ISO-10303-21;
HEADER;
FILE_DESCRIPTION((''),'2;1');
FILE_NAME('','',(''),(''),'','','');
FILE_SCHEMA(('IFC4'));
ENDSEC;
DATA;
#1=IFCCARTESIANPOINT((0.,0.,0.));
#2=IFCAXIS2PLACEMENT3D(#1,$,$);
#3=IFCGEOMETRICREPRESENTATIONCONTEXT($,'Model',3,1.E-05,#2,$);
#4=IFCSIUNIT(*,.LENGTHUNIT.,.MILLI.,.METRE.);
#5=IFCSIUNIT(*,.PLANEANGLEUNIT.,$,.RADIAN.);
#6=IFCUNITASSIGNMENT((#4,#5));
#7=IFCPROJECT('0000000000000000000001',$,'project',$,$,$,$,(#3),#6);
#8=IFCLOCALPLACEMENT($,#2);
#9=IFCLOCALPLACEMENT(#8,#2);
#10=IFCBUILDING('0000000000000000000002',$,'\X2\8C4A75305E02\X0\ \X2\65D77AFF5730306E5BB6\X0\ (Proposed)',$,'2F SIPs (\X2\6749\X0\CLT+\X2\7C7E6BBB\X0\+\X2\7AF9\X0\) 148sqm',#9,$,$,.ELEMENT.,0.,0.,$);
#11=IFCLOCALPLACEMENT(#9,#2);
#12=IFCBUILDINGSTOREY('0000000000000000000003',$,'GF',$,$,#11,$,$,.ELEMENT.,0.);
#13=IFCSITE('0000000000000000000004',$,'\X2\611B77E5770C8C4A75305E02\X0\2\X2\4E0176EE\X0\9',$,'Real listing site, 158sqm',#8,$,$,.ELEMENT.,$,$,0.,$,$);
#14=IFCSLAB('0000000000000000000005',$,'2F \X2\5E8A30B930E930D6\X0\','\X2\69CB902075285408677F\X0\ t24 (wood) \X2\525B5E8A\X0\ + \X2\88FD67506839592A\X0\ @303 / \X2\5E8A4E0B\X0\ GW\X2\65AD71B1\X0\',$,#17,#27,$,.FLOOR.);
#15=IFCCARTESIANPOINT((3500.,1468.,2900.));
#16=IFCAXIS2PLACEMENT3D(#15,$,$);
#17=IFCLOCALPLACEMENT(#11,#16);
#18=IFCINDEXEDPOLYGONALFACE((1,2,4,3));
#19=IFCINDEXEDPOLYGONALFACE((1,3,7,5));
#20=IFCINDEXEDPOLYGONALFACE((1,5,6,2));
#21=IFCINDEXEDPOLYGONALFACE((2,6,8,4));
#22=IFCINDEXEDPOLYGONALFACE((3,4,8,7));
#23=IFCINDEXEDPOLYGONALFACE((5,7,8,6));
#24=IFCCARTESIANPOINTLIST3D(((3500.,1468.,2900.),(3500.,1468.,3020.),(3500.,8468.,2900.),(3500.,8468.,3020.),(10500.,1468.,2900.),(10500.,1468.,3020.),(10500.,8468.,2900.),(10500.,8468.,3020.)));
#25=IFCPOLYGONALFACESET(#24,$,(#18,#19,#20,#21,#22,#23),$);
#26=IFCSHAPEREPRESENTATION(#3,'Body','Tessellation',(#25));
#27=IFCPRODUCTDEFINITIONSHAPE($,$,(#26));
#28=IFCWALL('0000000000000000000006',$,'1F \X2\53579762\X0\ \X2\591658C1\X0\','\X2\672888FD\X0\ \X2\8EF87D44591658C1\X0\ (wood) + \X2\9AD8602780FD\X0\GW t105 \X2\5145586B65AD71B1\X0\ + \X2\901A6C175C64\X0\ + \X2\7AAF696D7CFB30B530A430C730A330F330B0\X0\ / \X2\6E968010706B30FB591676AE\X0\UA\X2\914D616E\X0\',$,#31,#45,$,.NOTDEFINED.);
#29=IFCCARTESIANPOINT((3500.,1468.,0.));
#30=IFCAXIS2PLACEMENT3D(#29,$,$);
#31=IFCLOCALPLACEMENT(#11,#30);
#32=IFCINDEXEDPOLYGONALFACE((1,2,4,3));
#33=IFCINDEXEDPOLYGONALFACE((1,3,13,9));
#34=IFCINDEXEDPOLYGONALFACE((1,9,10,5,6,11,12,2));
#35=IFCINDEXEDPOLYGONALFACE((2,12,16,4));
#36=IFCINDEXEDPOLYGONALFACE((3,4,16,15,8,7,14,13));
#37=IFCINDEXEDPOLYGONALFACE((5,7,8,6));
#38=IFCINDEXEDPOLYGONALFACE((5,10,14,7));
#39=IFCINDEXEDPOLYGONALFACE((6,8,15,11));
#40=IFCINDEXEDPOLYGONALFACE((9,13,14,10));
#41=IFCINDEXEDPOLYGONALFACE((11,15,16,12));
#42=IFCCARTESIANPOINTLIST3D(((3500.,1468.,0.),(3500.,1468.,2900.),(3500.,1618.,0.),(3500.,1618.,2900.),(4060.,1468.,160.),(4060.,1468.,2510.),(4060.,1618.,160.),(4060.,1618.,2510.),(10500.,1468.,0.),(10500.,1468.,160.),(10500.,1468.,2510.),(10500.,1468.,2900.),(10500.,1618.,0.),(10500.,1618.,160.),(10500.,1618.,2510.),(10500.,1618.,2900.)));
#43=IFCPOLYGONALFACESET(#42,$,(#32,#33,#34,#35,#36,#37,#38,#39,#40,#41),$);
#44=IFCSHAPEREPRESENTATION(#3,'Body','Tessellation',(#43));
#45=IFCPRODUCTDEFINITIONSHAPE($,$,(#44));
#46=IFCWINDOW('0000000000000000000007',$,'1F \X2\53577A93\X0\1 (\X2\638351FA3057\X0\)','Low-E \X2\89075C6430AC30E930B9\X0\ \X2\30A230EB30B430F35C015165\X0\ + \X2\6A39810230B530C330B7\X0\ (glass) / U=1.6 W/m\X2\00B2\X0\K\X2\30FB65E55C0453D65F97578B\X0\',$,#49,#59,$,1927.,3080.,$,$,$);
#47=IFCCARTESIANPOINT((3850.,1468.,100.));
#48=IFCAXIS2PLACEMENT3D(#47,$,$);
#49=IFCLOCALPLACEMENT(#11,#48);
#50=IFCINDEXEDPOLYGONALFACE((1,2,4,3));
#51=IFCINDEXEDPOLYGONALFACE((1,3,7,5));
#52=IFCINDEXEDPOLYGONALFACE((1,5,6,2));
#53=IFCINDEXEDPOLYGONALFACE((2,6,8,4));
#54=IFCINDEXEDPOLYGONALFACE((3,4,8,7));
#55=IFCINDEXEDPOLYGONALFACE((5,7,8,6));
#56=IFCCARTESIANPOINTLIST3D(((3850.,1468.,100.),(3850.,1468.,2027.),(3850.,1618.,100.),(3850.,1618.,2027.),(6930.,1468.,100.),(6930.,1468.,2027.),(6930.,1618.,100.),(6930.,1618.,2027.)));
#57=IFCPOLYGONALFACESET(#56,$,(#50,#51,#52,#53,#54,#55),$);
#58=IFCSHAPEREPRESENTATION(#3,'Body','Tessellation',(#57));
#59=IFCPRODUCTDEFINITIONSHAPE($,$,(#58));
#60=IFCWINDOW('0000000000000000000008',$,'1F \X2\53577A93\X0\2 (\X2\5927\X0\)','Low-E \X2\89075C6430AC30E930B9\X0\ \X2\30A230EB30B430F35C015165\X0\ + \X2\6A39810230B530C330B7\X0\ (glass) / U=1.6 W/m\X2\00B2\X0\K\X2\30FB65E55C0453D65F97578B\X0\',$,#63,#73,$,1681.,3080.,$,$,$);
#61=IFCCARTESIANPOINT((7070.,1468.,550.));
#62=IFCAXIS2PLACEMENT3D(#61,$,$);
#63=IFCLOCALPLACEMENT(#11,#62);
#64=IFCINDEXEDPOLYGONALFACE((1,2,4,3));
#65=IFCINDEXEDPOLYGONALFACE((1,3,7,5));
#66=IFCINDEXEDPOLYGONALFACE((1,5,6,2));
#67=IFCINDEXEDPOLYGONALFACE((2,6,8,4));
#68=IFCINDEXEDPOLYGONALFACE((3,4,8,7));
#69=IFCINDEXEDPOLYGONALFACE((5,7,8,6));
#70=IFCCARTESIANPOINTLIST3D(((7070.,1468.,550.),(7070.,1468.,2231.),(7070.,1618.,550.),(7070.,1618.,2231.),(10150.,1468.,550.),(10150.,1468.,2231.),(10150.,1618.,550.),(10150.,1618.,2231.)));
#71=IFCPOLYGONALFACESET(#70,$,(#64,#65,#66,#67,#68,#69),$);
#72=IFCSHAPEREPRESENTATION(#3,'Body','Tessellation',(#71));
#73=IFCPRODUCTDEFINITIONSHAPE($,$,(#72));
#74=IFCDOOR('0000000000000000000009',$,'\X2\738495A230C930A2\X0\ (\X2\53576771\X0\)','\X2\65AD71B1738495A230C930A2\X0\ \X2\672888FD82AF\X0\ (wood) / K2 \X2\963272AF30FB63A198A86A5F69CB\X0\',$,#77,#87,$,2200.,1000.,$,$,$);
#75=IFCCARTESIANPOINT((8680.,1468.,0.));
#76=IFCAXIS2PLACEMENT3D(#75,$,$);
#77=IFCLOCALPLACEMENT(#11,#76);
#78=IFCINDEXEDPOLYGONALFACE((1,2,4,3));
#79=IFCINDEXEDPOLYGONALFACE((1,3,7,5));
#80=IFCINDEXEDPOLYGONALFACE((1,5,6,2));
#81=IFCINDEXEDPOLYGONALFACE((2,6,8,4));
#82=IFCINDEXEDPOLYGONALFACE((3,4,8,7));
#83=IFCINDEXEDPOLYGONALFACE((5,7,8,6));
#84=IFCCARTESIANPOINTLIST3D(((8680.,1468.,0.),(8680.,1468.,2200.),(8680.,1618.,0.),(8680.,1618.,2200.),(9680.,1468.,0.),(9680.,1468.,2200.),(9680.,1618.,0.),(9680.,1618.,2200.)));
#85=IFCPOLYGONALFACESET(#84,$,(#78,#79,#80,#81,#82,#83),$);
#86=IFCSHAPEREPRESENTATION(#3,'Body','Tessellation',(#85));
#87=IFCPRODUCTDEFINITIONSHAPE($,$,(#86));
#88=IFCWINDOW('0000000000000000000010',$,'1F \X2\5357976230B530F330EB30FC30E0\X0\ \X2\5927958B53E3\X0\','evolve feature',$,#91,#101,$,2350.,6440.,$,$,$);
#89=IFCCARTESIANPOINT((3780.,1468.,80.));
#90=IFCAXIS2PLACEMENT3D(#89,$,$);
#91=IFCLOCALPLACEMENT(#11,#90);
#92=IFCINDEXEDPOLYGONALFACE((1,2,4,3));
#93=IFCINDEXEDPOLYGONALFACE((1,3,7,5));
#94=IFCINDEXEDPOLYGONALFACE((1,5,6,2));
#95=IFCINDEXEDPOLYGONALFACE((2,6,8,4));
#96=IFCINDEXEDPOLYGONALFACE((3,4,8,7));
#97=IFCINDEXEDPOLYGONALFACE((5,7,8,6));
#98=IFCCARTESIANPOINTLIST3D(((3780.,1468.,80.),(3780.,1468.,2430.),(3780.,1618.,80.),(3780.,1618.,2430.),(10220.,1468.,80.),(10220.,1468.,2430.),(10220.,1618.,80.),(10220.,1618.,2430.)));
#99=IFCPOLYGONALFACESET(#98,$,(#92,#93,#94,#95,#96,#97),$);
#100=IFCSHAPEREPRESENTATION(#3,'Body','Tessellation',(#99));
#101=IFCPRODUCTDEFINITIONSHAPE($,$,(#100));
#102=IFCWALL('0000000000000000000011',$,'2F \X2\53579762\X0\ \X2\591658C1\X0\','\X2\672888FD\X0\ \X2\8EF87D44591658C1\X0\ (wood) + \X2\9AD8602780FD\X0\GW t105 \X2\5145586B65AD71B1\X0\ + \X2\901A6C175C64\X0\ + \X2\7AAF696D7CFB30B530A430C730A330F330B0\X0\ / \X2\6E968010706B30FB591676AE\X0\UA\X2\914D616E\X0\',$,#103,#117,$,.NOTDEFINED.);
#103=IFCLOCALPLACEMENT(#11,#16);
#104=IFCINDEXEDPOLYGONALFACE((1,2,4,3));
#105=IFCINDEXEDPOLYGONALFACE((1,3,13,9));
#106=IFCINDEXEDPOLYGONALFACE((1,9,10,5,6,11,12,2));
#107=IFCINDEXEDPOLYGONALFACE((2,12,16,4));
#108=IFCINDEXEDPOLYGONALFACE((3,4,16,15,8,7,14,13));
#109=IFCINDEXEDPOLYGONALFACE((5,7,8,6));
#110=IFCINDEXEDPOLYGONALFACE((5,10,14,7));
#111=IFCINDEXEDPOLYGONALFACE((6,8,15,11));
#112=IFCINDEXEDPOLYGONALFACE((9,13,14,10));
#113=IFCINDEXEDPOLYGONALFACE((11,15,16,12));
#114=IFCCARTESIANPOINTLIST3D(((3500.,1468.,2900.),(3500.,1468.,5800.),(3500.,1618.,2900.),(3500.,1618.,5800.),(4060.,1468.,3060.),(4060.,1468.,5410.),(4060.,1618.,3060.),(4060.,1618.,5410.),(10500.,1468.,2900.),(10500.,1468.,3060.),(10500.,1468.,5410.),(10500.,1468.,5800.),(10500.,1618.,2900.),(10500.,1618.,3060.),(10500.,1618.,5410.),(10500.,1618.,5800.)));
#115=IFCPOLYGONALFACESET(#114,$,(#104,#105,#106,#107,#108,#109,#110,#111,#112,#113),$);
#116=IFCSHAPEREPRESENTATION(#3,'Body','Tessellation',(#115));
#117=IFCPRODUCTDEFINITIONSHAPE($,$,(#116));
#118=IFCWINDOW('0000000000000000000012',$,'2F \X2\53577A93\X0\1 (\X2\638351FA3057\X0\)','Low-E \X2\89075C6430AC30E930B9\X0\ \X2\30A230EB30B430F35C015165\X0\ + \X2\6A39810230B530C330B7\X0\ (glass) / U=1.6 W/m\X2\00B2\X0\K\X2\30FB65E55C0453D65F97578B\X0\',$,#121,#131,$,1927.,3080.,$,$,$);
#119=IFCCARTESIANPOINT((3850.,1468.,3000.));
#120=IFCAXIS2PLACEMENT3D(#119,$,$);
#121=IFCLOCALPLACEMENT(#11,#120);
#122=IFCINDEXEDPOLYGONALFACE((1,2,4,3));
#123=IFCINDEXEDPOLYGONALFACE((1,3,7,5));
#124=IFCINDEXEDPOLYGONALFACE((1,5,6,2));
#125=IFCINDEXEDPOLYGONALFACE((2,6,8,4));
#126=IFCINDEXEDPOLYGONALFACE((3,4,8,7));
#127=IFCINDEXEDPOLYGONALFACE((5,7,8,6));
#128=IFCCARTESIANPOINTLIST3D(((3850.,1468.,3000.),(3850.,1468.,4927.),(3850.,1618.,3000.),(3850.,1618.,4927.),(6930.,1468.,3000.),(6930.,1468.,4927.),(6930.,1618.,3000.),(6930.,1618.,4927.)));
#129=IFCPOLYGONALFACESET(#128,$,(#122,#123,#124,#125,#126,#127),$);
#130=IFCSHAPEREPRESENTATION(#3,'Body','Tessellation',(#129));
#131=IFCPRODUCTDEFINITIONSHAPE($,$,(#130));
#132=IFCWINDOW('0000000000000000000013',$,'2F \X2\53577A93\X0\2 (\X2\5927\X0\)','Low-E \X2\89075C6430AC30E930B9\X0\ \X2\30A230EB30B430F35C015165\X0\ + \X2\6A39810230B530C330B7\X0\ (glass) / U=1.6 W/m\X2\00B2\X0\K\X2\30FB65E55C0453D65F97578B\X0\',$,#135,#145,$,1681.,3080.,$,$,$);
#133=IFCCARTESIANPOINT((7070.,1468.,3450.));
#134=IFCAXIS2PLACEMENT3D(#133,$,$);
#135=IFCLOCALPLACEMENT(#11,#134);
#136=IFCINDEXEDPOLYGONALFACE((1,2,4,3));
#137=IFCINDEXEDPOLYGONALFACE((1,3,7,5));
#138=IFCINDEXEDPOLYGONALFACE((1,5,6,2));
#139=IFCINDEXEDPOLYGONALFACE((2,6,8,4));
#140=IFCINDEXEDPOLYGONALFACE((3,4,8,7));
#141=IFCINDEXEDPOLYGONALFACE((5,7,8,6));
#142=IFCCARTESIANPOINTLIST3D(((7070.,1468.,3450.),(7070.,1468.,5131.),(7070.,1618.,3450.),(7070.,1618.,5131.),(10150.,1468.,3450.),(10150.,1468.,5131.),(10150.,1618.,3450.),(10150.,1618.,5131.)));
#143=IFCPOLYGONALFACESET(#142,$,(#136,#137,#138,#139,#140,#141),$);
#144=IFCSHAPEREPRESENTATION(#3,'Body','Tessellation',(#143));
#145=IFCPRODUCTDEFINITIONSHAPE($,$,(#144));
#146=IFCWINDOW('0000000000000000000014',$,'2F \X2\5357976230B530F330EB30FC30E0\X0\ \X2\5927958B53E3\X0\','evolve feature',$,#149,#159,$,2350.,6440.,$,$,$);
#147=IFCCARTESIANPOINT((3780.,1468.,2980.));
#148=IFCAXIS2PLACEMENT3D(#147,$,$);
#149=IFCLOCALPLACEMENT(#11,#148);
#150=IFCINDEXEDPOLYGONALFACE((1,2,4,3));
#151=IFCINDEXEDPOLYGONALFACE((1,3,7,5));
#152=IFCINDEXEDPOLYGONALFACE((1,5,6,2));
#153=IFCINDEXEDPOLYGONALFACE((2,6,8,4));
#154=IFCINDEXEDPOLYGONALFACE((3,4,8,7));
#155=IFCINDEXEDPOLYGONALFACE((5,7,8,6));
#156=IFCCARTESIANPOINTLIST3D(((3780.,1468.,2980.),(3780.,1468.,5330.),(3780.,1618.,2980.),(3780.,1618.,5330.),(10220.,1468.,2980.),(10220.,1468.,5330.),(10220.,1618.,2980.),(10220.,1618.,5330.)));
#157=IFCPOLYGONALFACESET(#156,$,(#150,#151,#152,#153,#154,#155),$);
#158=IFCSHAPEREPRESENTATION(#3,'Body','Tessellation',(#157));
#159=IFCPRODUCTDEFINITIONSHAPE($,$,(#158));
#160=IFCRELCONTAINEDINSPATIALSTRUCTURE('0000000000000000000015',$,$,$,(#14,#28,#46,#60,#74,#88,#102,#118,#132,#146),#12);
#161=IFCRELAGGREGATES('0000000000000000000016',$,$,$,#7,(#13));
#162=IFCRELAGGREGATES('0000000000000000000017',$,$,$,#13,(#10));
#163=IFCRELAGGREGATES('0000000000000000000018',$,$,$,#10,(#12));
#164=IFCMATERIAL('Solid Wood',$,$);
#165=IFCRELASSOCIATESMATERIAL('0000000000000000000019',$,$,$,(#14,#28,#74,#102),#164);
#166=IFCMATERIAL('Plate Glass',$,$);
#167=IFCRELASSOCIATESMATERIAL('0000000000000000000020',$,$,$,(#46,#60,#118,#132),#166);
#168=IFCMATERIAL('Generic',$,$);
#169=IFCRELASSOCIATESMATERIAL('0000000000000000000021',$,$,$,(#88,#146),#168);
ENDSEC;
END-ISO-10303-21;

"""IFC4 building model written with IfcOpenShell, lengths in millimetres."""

from ifc_helpers import new_model, si_unit, frame, frame_2d, origin, place, context, project, spatial, rectangle, extrude, material, element, fill, save


model = new_model("IFC4")

# Units and contexts
model_context = context("Model", 3, precision=1e-05, world=origin())
ifc_project = project(units=[si_unit("LENGTHUNIT", "METRE", prefix="MILLI"), si_unit("PLANEANGLEUNIT", "RADIAN")], contexts=[model_context])

# Site, building, storey
site_placement = place(None, origin())
site = spatial("IfcSite", under=ifc_project, at=site_placement, Name="愛知県豊田市2丁目9", ObjectType="Real listing site, 158sqm", CompositionType="ELEMENT", RefElevation=0.0)
building_placement = place(site_placement, origin())
building = spatial("IfcBuilding", under=site, at=building_placement, Name="豊田市 旗竿地の家 (Proposed)", ObjectType="2F SIPs (杉CLT+籾殻+竹) 148sqm", CompositionType="ELEMENT", ElevationOfRefHeight=0.0, ElevationOfTerrain=0.0)
storey_placement = place(building_placement, origin())
storey = spatial("IfcBuildingStorey", under=building, at=storey_placement, Name="GF", CompositionType="ELEMENT", Elevation=0.0)

# Slab
ifc_material_1 = material(Name="Solid Wood")
slab_1_placement = place(storey_placement, frame((3500.0, 1468.0, 2900.0)))
element("IfcSlab", 1, at=slab_1_placement, inside=storey, material=ifc_material_1, Name="2F 床スラブ", Description="構造用合板 t24 (wood) 剛床 + 製材根太 @303 / 床下 GW断熱", PredefinedType="FLOOR", context=model_context, shape_type="SweptSolid", body=[
    extrude(rectangle(XDim=7000.0, YDim=7000.0, at=frame_2d((3500.0, 3500.0))), frame((3500.0, 1468.0, 2900.0)), (0.0, 0.0, 1.0), 120.0),
])
ifc_material_2 = material(Name="Generic")

# Wall, openings, windows, door
wall_1_placement = place(storey_placement, frame((3500.0, 1468.0, 0.0)))
wall_1 = element("IfcWall", 2, at=wall_1_placement, inside=storey, material=ifc_material_1, Name="1F 南面 外壁", Description="木製 軸組外壁 (wood) + 高性能GW t105 充填断熱 + 通気層 + 窯業系サイディング / 準耐火・外皮UA配慮", PredefinedType="NOTDEFINED", context=model_context, shape_type="SweptSolid", body=[
    extrude(rectangle(XDim=7000.0, YDim=150.0, at=frame_2d((3500.0, 75.0))), frame((3500.0, 1468.0, 0.0)), (0.0, 0.0, 1.0), 2900.0),
])
opening_1_placement = place(storey_placement, frame((3850.0, 1468.0, 100.0)))
opening_1 = element("IfcOpeningElement", 3, at=opening_1_placement, cuts=wall_1, PredefinedType="NOTDEFINED", context=model_context, shape_type="SweptSolid", body=[
    extrude(rectangle(XDim=3080.0, YDim=150.0, at=frame_2d((1540.0, 75.0))), frame((3850.0, 1468.0, 100.0)), (0.0, 0.0, 1.0), 1927.0),
])
opening_2_placement = place(storey_placement, frame((7070.0, 1468.0, 550.0)))
opening_2 = element("IfcOpeningElement", 4, at=opening_2_placement, cuts=wall_1, PredefinedType="NOTDEFINED", context=model_context, shape_type="SweptSolid", body=[
    extrude(rectangle(XDim=3080.0, YDim=150.0, at=frame_2d((1540.0, 75.0))), frame((7070.0, 1468.0, 550.0)), (0.0, 0.0, 1.0), 1681.0),
])
opening_3_placement = place(storey_placement, frame((8680.0, 1468.0, 0.0)))
opening_3 = element("IfcOpeningElement", 5, at=opening_3_placement, cuts=wall_1, PredefinedType="NOTDEFINED", context=model_context, shape_type="SweptSolid", body=[
    extrude(rectangle(XDim=1000.0, YDim=150.0, at=frame_2d((500.0, 75.0))), frame((8680.0, 1468.0, 0.0)), (0.0, 0.0, 1.0), 2200.0),
])
opening_4_placement = place(storey_placement, frame((3780.0, 1468.0, 80.0)))
opening_4 = element("IfcOpeningElement", 6, at=opening_4_placement, cuts=wall_1, PredefinedType="NOTDEFINED", context=model_context, shape_type="SweptSolid", body=[
    extrude(rectangle(XDim=6440.0, YDim=150.0, at=frame_2d((3220.0, 75.0))), frame((3780.0, 1468.0, 80.0)), (0.0, 0.0, 1.0), 2350.0),
])
ifc_material_3 = material(Name="Plate Glass")
window_1_placement = place(storey_placement, frame((3850.0, 1468.0, 100.0)))
window_1 = element("IfcWindow", 7, at=window_1_placement, inside=storey, material=ifc_material_3, Name="1F 南窓1 (掃出し)", Description="Low-E 複層ガラス アルゴン封入 + 樹脂サッシ (glass) / U=1.6 W/m²K・日射取得型", OverallHeight=1927.0, OverallWidth=3080.0, context=model_context, shape_type="SweptSolid", body=[
    extrude(rectangle(XDim=3080.0, YDim=150.0, at=frame_2d((1540.0, 75.0))), frame((3850.0, 1468.0, 100.0)), (0.0, 0.0, 1.0), 1927.0),
])
fill(opening_1, window_1)
window_2_placement = place(storey_placement, frame((7070.0, 1468.0, 550.0)))
window_2 = element("IfcWindow", 8, at=window_2_placement, inside=storey, material=ifc_material_3, Name="1F 南窓2 (大)", Description="Low-E 複層ガラス アルゴン封入 + 樹脂サッシ (glass) / U=1.6 W/m²K・日射取得型", OverallHeight=1681.0, OverallWidth=3080.0, context=model_context, shape_type="SweptSolid", body=[
    extrude(rectangle(XDim=3080.0, YDim=150.0, at=frame_2d((1540.0, 75.0))), frame((7070.0, 1468.0, 550.0)), (0.0, 0.0, 1.0), 1681.0),
])
fill(opening_2, window_2)
door_placement = place(storey_placement, frame((8680.0, 1468.0, 0.0)))
door = element("IfcDoor", 9, at=door_placement, inside=storey, material=ifc_material_1, Name="玄関ドア (南東)", Description="断熱玄関ドア 木製芯 (wood) / K2 防犯・採風機構", OverallHeight=2200.0, OverallWidth=1000.0, context=model_context, shape_type="SweptSolid", body=[
    extrude(rectangle(XDim=1000.0, YDim=150.0, at=frame_2d((500.0, 75.0))), frame((8680.0, 1468.0, 0.0)), (0.0, 0.0, 1.0), 2200.0),
])
fill(opening_3, door)
window_3_placement = place(storey_placement, frame((3780.0, 1468.0, 80.0)))
window_3 = element("IfcWindow", 10, at=window_3_placement, inside=storey, material=ifc_material_2, Name="1F 南面サンルーム 大開口", Description="evolve feature", OverallHeight=2350.0, OverallWidth=6440.0, context=model_context, shape_type="SweptSolid", body=[
    extrude(rectangle(XDim=6440.0, YDim=150.0, at=frame_2d((3220.0, 75.0))), frame((3780.0, 1468.0, 80.0)), (0.0, 0.0, 1.0), 2350.0),
])
fill(opening_4, window_3)

# Wall, openings, windows
wall_2_placement = place(storey_placement, frame((3500.0, 1468.0, 2900.0)))
wall_2 = element("IfcWall", 11, at=wall_2_placement, inside=storey, material=ifc_material_1, Name="2F 南面 外壁", Description="木製 軸組外壁 (wood) + 高性能GW t105 充填断熱 + 通気層 + 窯業系サイディング / 準耐火・外皮UA配慮", PredefinedType="NOTDEFINED", context=model_context, shape_type="SweptSolid", body=[
    extrude(rectangle(XDim=7000.0, YDim=150.0, at=frame_2d((3500.0, 75.0))), frame((3500.0, 1468.0, 2900.0)), (0.0, 0.0, 1.0), 2900.0),
])
opening_5_placement = place(storey_placement, frame((3850.0, 1468.0, 3000.0)))
opening_5 = element("IfcOpeningElement", 12, at=opening_5_placement, cuts=wall_2, PredefinedType="NOTDEFINED", context=model_context, shape_type="SweptSolid", body=[
    extrude(rectangle(XDim=3080.0, YDim=150.0, at=frame_2d((1540.0, 75.0))), frame((3850.0, 1468.0, 3000.0)), (0.0, 0.0, 1.0), 1927.0),
])
opening_6_placement = place(storey_placement, frame((7070.0, 1468.0, 3450.0)))
opening_6 = element("IfcOpeningElement", 13, at=opening_6_placement, cuts=wall_2, PredefinedType="NOTDEFINED", context=model_context, shape_type="SweptSolid", body=[
    extrude(rectangle(XDim=3080.0, YDim=150.0, at=frame_2d((1540.0, 75.0))), frame((7070.0, 1468.0, 3450.0)), (0.0, 0.0, 1.0), 1681.0),
])
opening_7_placement = place(storey_placement, frame((3780.0, 1468.0, 2980.0)))
opening_7 = element("IfcOpeningElement", 14, at=opening_7_placement, cuts=wall_2, PredefinedType="NOTDEFINED", context=model_context, shape_type="SweptSolid", body=[
    extrude(rectangle(XDim=6440.0, YDim=150.0, at=frame_2d((3220.0, 75.0))), frame((3780.0, 1468.0, 2980.0)), (0.0, 0.0, 1.0), 2350.0),
])
window_4_placement = place(storey_placement, frame((3850.0, 1468.0, 3000.0)))
window_4 = element("IfcWindow", 15, at=window_4_placement, inside=storey, material=ifc_material_3, Name="2F 南窓1 (掃出し)", Description="Low-E 複層ガラス アルゴン封入 + 樹脂サッシ (glass) / U=1.6 W/m²K・日射取得型", OverallHeight=1927.0, OverallWidth=3080.0, context=model_context, shape_type="SweptSolid", body=[
    extrude(rectangle(XDim=3080.0, YDim=150.0, at=frame_2d((1540.0, 75.0))), frame((3850.0, 1468.0, 3000.0)), (0.0, 0.0, 1.0), 1927.0),
])
fill(opening_5, window_4)
window_5_placement = place(storey_placement, frame((7070.0, 1468.0, 3450.0)))
window_5 = element("IfcWindow", 16, at=window_5_placement, inside=storey, material=ifc_material_3, Name="2F 南窓2 (大)", Description="Low-E 複層ガラス アルゴン封入 + 樹脂サッシ (glass) / U=1.6 W/m²K・日射取得型", OverallHeight=1681.0, OverallWidth=3080.0, context=model_context, shape_type="SweptSolid", body=[
    extrude(rectangle(XDim=3080.0, YDim=150.0, at=frame_2d((1540.0, 75.0))), frame((7070.0, 1468.0, 3450.0)), (0.0, 0.0, 1.0), 1681.0),
])
fill(opening_6, window_5)
window_6_placement = place(storey_placement, frame((3780.0, 1468.0, 2980.0)))
window_6 = element("IfcWindow", 17, at=window_6_placement, inside=storey, material=ifc_material_2, Name="2F 南面サンルーム 大開口", Description="evolve feature", OverallHeight=2350.0, OverallWidth=6440.0, context=model_context, shape_type="SweptSolid", body=[
    extrude(rectangle(XDim=6440.0, YDim=150.0, at=frame_2d((3220.0, 75.0))), frame((3780.0, 1468.0, 2980.0)), (0.0, 0.0, 1.0), 2350.0),
])
fill(opening_7, window_6)

save(model, "model.ifc")
